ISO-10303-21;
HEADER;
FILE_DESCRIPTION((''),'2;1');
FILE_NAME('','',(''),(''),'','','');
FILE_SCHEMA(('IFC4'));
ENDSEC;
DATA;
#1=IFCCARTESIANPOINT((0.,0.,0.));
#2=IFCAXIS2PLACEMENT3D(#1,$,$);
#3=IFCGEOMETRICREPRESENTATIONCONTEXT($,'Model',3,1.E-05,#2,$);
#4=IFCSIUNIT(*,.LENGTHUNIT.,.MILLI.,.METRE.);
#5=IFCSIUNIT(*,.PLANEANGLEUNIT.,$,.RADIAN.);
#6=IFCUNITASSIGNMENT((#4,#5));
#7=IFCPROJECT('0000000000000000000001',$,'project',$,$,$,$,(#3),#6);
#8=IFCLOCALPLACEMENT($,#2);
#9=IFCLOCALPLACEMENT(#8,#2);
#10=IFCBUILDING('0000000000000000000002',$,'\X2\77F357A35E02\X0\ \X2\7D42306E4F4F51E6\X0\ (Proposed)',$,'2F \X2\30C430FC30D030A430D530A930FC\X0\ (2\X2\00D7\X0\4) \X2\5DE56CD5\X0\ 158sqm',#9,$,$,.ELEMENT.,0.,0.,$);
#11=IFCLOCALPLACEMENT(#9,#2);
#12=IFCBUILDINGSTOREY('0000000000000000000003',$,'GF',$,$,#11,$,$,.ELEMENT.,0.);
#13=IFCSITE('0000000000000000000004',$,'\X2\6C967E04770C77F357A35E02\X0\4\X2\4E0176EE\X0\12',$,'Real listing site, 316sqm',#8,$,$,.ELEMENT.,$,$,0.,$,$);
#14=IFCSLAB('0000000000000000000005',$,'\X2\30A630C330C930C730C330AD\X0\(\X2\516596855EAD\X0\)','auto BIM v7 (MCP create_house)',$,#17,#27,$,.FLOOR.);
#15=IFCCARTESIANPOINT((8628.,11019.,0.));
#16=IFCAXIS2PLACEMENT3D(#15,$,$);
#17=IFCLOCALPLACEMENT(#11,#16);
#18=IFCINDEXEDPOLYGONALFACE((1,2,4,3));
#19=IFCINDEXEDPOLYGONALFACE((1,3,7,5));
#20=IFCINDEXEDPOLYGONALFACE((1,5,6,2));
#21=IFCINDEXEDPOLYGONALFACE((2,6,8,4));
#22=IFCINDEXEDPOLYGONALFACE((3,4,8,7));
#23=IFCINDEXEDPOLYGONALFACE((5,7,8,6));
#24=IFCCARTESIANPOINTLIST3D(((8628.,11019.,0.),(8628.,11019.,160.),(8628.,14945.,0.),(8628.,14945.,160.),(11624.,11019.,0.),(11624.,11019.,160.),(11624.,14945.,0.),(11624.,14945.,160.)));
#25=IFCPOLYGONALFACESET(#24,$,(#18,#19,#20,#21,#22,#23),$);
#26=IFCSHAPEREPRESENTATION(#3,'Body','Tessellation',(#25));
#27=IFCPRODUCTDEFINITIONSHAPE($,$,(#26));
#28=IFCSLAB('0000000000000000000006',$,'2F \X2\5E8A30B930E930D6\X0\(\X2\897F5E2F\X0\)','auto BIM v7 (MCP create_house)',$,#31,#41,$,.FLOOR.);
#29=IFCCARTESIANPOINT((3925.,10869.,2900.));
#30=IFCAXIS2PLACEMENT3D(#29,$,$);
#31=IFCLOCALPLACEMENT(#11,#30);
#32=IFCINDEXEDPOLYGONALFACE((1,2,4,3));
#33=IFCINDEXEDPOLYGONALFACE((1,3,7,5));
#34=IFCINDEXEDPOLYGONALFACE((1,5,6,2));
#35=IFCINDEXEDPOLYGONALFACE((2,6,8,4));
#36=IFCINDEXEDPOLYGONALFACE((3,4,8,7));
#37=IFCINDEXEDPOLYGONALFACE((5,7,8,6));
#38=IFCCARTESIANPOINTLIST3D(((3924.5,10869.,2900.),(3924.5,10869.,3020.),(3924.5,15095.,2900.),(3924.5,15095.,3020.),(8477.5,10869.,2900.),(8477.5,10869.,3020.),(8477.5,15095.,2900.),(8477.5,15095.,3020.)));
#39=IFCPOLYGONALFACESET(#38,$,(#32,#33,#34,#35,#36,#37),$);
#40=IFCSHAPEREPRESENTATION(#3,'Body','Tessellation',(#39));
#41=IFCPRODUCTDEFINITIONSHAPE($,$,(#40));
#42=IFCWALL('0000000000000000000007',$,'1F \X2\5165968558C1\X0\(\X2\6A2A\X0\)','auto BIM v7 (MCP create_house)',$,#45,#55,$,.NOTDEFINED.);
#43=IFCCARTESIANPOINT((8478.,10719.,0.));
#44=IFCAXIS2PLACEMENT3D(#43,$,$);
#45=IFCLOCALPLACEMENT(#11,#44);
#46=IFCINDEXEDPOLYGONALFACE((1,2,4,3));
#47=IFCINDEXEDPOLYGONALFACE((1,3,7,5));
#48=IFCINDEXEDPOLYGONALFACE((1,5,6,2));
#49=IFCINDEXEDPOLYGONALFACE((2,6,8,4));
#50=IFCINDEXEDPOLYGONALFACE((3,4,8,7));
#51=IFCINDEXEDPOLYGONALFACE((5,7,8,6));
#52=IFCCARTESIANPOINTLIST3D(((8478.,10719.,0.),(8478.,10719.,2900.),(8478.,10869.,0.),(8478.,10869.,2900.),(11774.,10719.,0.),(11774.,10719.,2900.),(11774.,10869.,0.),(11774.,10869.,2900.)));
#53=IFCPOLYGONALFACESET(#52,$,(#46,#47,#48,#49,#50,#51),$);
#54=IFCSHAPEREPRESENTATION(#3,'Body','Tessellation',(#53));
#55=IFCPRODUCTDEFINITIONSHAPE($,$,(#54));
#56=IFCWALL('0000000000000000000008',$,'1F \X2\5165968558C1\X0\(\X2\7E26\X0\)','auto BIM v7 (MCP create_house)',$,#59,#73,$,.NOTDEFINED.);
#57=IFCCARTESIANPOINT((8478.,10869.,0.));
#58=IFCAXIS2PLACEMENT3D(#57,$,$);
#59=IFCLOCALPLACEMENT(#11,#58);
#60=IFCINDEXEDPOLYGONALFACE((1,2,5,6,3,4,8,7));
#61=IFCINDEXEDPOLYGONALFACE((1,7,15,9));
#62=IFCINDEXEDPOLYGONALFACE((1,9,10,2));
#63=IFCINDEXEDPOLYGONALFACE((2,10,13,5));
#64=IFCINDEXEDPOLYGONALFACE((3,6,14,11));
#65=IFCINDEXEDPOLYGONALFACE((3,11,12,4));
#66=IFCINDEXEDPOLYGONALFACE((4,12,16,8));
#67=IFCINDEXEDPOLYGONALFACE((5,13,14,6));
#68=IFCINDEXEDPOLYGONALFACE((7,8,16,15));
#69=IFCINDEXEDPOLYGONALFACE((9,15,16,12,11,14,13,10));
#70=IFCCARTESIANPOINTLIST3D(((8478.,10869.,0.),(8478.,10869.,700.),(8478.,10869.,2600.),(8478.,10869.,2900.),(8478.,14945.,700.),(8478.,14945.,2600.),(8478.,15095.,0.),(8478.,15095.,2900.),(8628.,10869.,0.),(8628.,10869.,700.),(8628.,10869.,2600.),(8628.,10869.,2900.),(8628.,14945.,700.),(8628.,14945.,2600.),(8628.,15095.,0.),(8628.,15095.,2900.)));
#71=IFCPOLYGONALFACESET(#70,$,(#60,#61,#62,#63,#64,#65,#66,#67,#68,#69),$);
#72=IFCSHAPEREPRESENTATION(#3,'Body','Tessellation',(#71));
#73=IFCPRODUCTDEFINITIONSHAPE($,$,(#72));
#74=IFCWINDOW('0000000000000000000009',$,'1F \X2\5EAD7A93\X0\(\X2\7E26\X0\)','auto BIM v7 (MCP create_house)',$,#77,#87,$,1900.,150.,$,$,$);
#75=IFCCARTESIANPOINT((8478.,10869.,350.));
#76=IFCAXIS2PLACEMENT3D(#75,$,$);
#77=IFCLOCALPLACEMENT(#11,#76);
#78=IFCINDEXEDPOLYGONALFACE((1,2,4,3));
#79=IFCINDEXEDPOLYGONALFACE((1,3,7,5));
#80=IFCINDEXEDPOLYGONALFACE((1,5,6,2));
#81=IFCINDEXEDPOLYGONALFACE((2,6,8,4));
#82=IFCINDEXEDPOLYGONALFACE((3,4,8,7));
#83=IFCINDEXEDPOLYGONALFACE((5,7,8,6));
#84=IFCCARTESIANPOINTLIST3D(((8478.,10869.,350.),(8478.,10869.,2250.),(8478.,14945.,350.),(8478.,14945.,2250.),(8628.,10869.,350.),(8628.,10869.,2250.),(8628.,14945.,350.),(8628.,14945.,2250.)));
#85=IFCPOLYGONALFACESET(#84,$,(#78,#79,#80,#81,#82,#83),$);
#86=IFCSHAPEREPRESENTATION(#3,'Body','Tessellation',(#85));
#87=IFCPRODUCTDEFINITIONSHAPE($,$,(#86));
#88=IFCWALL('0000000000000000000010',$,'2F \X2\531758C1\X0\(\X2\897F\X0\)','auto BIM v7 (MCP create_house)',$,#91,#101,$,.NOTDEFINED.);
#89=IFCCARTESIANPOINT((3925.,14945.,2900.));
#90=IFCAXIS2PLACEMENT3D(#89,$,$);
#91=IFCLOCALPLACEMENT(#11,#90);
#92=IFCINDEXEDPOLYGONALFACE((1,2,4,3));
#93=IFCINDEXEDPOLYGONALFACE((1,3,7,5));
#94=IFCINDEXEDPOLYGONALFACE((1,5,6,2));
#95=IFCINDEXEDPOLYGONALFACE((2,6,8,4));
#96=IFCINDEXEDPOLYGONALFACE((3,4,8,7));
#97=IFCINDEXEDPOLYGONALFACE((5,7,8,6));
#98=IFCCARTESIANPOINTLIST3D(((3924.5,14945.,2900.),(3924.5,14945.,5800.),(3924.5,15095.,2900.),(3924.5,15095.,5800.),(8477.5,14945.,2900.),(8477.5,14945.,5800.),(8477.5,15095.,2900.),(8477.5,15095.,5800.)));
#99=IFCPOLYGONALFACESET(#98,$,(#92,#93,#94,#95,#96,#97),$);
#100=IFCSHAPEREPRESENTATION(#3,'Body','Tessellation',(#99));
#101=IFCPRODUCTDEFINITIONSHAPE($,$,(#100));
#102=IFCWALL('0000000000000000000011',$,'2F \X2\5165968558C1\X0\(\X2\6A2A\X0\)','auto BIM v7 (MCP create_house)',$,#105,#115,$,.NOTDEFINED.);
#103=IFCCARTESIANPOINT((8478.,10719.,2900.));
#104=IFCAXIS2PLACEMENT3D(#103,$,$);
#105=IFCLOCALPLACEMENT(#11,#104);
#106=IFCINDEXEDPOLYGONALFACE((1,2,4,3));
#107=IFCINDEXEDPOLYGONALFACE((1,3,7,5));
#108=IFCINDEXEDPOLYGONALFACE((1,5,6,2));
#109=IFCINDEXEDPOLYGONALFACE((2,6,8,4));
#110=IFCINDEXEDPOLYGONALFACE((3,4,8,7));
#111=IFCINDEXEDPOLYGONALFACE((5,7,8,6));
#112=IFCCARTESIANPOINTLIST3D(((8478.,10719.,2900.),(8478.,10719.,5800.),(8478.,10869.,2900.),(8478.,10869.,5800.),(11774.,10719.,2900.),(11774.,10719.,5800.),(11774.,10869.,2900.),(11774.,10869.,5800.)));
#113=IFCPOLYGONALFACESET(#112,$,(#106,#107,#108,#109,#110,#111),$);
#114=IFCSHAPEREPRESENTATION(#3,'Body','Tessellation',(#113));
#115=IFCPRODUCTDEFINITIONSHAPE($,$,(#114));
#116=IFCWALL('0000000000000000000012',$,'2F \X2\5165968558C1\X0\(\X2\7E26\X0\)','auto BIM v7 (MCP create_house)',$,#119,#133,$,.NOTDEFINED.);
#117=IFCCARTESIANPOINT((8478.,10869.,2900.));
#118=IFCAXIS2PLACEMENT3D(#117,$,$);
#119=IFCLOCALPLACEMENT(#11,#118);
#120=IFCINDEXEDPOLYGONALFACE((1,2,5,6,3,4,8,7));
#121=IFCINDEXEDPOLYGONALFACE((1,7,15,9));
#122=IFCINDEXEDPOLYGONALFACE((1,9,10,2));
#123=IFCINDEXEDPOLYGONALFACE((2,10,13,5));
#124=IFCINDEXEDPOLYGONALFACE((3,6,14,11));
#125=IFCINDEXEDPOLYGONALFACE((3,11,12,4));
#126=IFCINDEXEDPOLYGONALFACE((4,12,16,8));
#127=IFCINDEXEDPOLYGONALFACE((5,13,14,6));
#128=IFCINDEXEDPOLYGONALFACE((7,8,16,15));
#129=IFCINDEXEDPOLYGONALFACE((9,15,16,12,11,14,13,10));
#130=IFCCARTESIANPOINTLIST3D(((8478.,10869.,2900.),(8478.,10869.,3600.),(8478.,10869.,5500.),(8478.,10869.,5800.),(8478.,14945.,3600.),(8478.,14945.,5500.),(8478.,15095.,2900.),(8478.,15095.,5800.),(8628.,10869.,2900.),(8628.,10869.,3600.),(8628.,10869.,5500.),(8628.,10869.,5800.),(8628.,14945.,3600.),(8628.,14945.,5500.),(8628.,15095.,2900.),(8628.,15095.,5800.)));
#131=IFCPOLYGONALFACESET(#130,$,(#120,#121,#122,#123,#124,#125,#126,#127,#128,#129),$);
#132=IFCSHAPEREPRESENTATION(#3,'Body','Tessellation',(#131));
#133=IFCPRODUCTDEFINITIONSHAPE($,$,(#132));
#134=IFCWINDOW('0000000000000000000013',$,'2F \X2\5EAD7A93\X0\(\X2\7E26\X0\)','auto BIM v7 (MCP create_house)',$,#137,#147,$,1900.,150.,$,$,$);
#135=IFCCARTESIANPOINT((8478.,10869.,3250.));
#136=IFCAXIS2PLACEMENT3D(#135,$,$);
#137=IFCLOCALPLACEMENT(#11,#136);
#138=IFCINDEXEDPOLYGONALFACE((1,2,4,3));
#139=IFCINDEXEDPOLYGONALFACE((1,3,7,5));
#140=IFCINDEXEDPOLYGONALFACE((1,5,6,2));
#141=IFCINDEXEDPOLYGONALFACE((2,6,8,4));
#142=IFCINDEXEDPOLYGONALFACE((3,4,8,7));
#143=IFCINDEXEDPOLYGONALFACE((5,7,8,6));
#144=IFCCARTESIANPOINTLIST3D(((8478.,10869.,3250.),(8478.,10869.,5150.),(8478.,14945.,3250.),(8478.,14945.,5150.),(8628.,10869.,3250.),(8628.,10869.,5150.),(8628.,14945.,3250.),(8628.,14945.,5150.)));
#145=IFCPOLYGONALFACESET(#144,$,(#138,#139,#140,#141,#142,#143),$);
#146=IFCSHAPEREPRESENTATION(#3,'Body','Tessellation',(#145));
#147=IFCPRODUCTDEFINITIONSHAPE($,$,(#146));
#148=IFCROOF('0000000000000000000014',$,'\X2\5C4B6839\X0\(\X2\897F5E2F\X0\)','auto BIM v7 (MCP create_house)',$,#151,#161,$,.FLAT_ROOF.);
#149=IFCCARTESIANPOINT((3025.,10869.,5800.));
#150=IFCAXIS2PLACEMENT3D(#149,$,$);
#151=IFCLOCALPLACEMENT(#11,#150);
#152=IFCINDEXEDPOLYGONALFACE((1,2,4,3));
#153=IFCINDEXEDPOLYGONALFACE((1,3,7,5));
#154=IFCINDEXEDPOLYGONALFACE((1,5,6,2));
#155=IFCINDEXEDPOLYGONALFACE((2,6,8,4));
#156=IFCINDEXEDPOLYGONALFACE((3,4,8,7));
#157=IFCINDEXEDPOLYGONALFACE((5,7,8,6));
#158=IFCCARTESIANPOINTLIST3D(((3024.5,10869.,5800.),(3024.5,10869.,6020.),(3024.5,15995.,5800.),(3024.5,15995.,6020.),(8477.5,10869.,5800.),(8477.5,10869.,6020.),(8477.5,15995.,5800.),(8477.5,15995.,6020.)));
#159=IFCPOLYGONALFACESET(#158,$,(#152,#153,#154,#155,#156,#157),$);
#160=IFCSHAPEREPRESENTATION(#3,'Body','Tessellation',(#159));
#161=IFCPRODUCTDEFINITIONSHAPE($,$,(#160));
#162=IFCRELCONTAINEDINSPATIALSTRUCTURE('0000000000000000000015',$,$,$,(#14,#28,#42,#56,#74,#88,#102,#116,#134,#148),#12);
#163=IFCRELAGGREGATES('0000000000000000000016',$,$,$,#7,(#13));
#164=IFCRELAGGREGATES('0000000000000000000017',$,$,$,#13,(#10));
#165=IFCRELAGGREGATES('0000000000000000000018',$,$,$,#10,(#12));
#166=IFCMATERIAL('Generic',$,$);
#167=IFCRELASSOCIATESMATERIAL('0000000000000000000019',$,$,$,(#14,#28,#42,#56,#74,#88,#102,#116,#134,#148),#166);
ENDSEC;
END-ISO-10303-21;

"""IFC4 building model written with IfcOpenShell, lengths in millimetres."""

from ifc_helpers import new_model, si_unit, frame, frame_2d, origin, place, context, project, spatial, rectangle, extrude, material, element, fill, save


model = new_model("IFC4")

# Units and contexts
model_context = context("Model", 3, precision=1e-05, world=origin())
ifc_project = project(units=[si_unit("LENGTHUNIT", "METRE", prefix="MILLI"), si_unit("PLANEANGLEUNIT", "RADIAN")], contexts=[model_context])

# Site, building, storey
site_placement = place(None, origin())
site = spatial("IfcSite", under=ifc_project, at=site_placement, Name="沖縄県石垣市4丁目12", ObjectType="Real listing site, 316sqm", CompositionType="ELEMENT", RefElevation=0.0)
building_placement = place(site_placement, origin())
building = spatial("IfcBuilding", under=site, at=building_placement, Name="石垣市 終の住処 (Proposed)", ObjectType="2F ツーバイフォー (2×4) 工法 158sqm", CompositionType="ELEMENT", ElevationOfRefHeight=0.0, ElevationOfTerrain=0.0)
storey_placement = place(building_placement, origin())
storey = spatial("IfcBuildingStorey", under=building, at=storey_placement, Name="GF", CompositionType="ELEMENT", Elevation=0.0)

# Slabs
ifc_material = material(Name="Generic")
slab_1_placement = place(storey_placement, frame((8628.0, 11019.0, 0.0)))
element("IfcSlab", 1, at=slab_1_placement, inside=storey, material=ifc_material, Name="ウッドデッキ(入隅庭)", Description="auto BIM v7 (MCP create_house)", PredefinedType="FLOOR", context=model_context, shape_type="SweptSolid", body=[
    extrude(rectangle(XDim=2996.0, YDim=3926.0, at=frame_2d((1498.0, 1963.0))), frame((8628.0, 11019.0, 0.0)), (0.0, 0.0, 1.0), 160.0),
])
slab_2_placement = place(storey_placement, frame((3925.0, 10869.0, 2900.0)))
element("IfcSlab", 2, at=slab_2_placement, inside=storey, material=ifc_material, Name="2F 床スラブ(西帯)", Description="auto BIM v7 (MCP create_house)", PredefinedType="FLOOR", context=model_context, shape_type="SweptSolid", body=[
    extrude(rectangle(XDim=4553.0, YDim=4226.0, at=frame_2d((2276.0, 2113.0))), frame((3925.0, 10869.0, 2900.0)), (0.0, 0.0, 1.0), 120.0),
])

# Wall
wall_1_placement = place(storey_placement, frame((8478.0, 10719.0, 0.0)))
element("IfcWall", 3, at=wall_1_placement, inside=storey, material=ifc_material, Name="1F 入隅壁(横)", Description="auto BIM v7 (MCP create_house)", PredefinedType="NOTDEFINED", context=model_context, shape_type="SweptSolid", body=[
    extrude(rectangle(XDim=3296.0, YDim=150.0, at=frame_2d((1648.0, 75.0))), frame((8478.0, 10719.0, 0.0)), (0.0, 0.0, 1.0), 2900.0),
])

# Wall, opening, window
wall_2_placement = place(storey_placement, frame((8478.0, 10869.0, 0.0)))
wall_2 = element("IfcWall", 4, at=wall_2_placement, inside=storey, material=ifc_material, Name="1F 入隅壁(縦)", Description="auto BIM v7 (MCP create_house)", PredefinedType="NOTDEFINED", context=model_context, shape_type="SweptSolid", body=[
    extrude(rectangle(XDim=150.0, YDim=4226.0, at=frame_2d((75.0, 2113.0))), frame((8478.0, 10869.0, 0.0)), (0.0, 0.0, 1.0), 2900.0),
])
opening_1_placement = place(storey_placement, frame((8478.0, 10869.0, 350.0)))
opening_1 = element("IfcOpeningElement", 5, at=opening_1_placement, cuts=wall_2, PredefinedType="NOTDEFINED", context=model_context, shape_type="SweptSolid", body=[
    extrude(rectangle(XDim=150.0, YDim=4076.0, at=frame_2d((75.0, 2038.0))), frame((8478.0, 10869.0, 350.0)), (0.0, 0.0, 1.0), 1900.0),
])
window_1_placement = place(storey_placement, frame((8478.0, 10869.0, 350.0)))
window_1 = element("IfcWindow", 6, at=window_1_placement, inside=storey, material=ifc_material, Name="1F 庭窓(縦)", Description="auto BIM v7 (MCP create_house)", OverallHeight=1900.0, OverallWidth=150.0, context=model_context, shape_type="SweptSolid", body=[
    extrude(rectangle(XDim=150.0, YDim=4076.0, at=frame_2d((75.0, 2038.0))), frame((8478.0, 10869.0, 350.0)), (0.0, 0.0, 1.0), 1900.0),
])
fill(opening_1, window_1)

# Walls
wall_3_placement = place(storey_placement, frame((3925.0, 14945.0, 2900.0)))
element("IfcWall", 7, at=wall_3_placement, inside=storey, material=ifc_material, Name="2F 北壁(西)", Description="auto BIM v7 (MCP create_house)", PredefinedType="NOTDEFINED", context=model_context, shape_type="SweptSolid", body=[
    extrude(rectangle(XDim=4553.0, YDim=150.0, at=frame_2d((2276.0, 75.0))), frame((3925.0, 14945.0, 2900.0)), (0.0, 0.0, 1.0), 2900.0),
])
wall_4_placement = place(storey_placement, frame((8478.0, 10719.0, 2900.0)))
element("IfcWall", 8, at=wall_4_placement, inside=storey, material=ifc_material, Name="2F 入隅壁(横)", Description="auto BIM v7 (MCP create_house)", PredefinedType="NOTDEFINED", context=model_context, shape_type="SweptSolid", body=[
    extrude(rectangle(XDim=3296.0, YDim=150.0, at=frame_2d((1648.0, 75.0))), frame((8478.0, 10719.0, 2900.0)), (0.0, 0.0, 1.0), 2900.0),
])

# Wall, opening, window
wall_5_placement = place(storey_placement, frame((8478.0, 10869.0, 2900.0)))
wall_5 = element("IfcWall", 9, at=wall_5_placement, inside=storey, material=ifc_material, Name="2F 入隅壁(縦)", Description="auto BIM v7 (MCP create_house)", PredefinedType="NOTDEFINED", context=model_context, shape_type="SweptSolid", body=[
    extrude(rectangle(XDim=150.0, YDim=4226.0, at=frame_2d((75.0, 2113.0))), frame((8478.0, 10869.0, 2900.0)), (0.0, 0.0, 1.0), 2900.0),
])
opening_2_placement = place(storey_placement, frame((8478.0, 10869.0, 3250.0)))
opening_2 = element("IfcOpeningElement", 10, at=opening_2_placement, cuts=wall_5, PredefinedType="NOTDEFINED", context=model_context, shape_type="SweptSolid", body=[
    extrude(rectangle(XDim=150.0, YDim=4076.0, at=frame_2d((75.0, 2038.0))), frame((8478.0, 10869.0, 3250.0)), (0.0, 0.0, 1.0), 1900.0),
])
window_2_placement = place(storey_placement, frame((8478.0, 10869.0, 3250.0)))
window_2 = element("IfcWindow", 11, at=window_2_placement, inside=storey, material=ifc_material, Name="2F 庭窓(縦)", Description="auto BIM v7 (MCP create_house)", OverallHeight=1900.0, OverallWidth=150.0, context=model_context, shape_type="SweptSolid", body=[
    extrude(rectangle(XDim=150.0, YDim=4076.0, at=frame_2d((75.0, 2038.0))), frame((8478.0, 10869.0, 3250.0)), (0.0, 0.0, 1.0), 1900.0),
])
fill(opening_2, window_2)

# Roof
for number, where, name in (
    (12, (3025.0, 10869.0, 5800.0), "屋根(西帯)"),
):
    element("IfcRoof", number, at=place(storey_placement, frame(where)), inside=storey, material=ifc_material, Name=name, Description="auto BIM v7 (MCP create_house)", PredefinedType="FLAT_ROOF", context=model_context, shape_type="SweptSolid", body=[
        extrude(rectangle(XDim=5453.0, YDim=5126.0, at=frame_2d((2726.0, 2563.0))), frame((3025.0, 10869.0, 5800.0)), (0.0, 0.0, 1.0), 220.0),
    ])

save(model, "model.ifc")
